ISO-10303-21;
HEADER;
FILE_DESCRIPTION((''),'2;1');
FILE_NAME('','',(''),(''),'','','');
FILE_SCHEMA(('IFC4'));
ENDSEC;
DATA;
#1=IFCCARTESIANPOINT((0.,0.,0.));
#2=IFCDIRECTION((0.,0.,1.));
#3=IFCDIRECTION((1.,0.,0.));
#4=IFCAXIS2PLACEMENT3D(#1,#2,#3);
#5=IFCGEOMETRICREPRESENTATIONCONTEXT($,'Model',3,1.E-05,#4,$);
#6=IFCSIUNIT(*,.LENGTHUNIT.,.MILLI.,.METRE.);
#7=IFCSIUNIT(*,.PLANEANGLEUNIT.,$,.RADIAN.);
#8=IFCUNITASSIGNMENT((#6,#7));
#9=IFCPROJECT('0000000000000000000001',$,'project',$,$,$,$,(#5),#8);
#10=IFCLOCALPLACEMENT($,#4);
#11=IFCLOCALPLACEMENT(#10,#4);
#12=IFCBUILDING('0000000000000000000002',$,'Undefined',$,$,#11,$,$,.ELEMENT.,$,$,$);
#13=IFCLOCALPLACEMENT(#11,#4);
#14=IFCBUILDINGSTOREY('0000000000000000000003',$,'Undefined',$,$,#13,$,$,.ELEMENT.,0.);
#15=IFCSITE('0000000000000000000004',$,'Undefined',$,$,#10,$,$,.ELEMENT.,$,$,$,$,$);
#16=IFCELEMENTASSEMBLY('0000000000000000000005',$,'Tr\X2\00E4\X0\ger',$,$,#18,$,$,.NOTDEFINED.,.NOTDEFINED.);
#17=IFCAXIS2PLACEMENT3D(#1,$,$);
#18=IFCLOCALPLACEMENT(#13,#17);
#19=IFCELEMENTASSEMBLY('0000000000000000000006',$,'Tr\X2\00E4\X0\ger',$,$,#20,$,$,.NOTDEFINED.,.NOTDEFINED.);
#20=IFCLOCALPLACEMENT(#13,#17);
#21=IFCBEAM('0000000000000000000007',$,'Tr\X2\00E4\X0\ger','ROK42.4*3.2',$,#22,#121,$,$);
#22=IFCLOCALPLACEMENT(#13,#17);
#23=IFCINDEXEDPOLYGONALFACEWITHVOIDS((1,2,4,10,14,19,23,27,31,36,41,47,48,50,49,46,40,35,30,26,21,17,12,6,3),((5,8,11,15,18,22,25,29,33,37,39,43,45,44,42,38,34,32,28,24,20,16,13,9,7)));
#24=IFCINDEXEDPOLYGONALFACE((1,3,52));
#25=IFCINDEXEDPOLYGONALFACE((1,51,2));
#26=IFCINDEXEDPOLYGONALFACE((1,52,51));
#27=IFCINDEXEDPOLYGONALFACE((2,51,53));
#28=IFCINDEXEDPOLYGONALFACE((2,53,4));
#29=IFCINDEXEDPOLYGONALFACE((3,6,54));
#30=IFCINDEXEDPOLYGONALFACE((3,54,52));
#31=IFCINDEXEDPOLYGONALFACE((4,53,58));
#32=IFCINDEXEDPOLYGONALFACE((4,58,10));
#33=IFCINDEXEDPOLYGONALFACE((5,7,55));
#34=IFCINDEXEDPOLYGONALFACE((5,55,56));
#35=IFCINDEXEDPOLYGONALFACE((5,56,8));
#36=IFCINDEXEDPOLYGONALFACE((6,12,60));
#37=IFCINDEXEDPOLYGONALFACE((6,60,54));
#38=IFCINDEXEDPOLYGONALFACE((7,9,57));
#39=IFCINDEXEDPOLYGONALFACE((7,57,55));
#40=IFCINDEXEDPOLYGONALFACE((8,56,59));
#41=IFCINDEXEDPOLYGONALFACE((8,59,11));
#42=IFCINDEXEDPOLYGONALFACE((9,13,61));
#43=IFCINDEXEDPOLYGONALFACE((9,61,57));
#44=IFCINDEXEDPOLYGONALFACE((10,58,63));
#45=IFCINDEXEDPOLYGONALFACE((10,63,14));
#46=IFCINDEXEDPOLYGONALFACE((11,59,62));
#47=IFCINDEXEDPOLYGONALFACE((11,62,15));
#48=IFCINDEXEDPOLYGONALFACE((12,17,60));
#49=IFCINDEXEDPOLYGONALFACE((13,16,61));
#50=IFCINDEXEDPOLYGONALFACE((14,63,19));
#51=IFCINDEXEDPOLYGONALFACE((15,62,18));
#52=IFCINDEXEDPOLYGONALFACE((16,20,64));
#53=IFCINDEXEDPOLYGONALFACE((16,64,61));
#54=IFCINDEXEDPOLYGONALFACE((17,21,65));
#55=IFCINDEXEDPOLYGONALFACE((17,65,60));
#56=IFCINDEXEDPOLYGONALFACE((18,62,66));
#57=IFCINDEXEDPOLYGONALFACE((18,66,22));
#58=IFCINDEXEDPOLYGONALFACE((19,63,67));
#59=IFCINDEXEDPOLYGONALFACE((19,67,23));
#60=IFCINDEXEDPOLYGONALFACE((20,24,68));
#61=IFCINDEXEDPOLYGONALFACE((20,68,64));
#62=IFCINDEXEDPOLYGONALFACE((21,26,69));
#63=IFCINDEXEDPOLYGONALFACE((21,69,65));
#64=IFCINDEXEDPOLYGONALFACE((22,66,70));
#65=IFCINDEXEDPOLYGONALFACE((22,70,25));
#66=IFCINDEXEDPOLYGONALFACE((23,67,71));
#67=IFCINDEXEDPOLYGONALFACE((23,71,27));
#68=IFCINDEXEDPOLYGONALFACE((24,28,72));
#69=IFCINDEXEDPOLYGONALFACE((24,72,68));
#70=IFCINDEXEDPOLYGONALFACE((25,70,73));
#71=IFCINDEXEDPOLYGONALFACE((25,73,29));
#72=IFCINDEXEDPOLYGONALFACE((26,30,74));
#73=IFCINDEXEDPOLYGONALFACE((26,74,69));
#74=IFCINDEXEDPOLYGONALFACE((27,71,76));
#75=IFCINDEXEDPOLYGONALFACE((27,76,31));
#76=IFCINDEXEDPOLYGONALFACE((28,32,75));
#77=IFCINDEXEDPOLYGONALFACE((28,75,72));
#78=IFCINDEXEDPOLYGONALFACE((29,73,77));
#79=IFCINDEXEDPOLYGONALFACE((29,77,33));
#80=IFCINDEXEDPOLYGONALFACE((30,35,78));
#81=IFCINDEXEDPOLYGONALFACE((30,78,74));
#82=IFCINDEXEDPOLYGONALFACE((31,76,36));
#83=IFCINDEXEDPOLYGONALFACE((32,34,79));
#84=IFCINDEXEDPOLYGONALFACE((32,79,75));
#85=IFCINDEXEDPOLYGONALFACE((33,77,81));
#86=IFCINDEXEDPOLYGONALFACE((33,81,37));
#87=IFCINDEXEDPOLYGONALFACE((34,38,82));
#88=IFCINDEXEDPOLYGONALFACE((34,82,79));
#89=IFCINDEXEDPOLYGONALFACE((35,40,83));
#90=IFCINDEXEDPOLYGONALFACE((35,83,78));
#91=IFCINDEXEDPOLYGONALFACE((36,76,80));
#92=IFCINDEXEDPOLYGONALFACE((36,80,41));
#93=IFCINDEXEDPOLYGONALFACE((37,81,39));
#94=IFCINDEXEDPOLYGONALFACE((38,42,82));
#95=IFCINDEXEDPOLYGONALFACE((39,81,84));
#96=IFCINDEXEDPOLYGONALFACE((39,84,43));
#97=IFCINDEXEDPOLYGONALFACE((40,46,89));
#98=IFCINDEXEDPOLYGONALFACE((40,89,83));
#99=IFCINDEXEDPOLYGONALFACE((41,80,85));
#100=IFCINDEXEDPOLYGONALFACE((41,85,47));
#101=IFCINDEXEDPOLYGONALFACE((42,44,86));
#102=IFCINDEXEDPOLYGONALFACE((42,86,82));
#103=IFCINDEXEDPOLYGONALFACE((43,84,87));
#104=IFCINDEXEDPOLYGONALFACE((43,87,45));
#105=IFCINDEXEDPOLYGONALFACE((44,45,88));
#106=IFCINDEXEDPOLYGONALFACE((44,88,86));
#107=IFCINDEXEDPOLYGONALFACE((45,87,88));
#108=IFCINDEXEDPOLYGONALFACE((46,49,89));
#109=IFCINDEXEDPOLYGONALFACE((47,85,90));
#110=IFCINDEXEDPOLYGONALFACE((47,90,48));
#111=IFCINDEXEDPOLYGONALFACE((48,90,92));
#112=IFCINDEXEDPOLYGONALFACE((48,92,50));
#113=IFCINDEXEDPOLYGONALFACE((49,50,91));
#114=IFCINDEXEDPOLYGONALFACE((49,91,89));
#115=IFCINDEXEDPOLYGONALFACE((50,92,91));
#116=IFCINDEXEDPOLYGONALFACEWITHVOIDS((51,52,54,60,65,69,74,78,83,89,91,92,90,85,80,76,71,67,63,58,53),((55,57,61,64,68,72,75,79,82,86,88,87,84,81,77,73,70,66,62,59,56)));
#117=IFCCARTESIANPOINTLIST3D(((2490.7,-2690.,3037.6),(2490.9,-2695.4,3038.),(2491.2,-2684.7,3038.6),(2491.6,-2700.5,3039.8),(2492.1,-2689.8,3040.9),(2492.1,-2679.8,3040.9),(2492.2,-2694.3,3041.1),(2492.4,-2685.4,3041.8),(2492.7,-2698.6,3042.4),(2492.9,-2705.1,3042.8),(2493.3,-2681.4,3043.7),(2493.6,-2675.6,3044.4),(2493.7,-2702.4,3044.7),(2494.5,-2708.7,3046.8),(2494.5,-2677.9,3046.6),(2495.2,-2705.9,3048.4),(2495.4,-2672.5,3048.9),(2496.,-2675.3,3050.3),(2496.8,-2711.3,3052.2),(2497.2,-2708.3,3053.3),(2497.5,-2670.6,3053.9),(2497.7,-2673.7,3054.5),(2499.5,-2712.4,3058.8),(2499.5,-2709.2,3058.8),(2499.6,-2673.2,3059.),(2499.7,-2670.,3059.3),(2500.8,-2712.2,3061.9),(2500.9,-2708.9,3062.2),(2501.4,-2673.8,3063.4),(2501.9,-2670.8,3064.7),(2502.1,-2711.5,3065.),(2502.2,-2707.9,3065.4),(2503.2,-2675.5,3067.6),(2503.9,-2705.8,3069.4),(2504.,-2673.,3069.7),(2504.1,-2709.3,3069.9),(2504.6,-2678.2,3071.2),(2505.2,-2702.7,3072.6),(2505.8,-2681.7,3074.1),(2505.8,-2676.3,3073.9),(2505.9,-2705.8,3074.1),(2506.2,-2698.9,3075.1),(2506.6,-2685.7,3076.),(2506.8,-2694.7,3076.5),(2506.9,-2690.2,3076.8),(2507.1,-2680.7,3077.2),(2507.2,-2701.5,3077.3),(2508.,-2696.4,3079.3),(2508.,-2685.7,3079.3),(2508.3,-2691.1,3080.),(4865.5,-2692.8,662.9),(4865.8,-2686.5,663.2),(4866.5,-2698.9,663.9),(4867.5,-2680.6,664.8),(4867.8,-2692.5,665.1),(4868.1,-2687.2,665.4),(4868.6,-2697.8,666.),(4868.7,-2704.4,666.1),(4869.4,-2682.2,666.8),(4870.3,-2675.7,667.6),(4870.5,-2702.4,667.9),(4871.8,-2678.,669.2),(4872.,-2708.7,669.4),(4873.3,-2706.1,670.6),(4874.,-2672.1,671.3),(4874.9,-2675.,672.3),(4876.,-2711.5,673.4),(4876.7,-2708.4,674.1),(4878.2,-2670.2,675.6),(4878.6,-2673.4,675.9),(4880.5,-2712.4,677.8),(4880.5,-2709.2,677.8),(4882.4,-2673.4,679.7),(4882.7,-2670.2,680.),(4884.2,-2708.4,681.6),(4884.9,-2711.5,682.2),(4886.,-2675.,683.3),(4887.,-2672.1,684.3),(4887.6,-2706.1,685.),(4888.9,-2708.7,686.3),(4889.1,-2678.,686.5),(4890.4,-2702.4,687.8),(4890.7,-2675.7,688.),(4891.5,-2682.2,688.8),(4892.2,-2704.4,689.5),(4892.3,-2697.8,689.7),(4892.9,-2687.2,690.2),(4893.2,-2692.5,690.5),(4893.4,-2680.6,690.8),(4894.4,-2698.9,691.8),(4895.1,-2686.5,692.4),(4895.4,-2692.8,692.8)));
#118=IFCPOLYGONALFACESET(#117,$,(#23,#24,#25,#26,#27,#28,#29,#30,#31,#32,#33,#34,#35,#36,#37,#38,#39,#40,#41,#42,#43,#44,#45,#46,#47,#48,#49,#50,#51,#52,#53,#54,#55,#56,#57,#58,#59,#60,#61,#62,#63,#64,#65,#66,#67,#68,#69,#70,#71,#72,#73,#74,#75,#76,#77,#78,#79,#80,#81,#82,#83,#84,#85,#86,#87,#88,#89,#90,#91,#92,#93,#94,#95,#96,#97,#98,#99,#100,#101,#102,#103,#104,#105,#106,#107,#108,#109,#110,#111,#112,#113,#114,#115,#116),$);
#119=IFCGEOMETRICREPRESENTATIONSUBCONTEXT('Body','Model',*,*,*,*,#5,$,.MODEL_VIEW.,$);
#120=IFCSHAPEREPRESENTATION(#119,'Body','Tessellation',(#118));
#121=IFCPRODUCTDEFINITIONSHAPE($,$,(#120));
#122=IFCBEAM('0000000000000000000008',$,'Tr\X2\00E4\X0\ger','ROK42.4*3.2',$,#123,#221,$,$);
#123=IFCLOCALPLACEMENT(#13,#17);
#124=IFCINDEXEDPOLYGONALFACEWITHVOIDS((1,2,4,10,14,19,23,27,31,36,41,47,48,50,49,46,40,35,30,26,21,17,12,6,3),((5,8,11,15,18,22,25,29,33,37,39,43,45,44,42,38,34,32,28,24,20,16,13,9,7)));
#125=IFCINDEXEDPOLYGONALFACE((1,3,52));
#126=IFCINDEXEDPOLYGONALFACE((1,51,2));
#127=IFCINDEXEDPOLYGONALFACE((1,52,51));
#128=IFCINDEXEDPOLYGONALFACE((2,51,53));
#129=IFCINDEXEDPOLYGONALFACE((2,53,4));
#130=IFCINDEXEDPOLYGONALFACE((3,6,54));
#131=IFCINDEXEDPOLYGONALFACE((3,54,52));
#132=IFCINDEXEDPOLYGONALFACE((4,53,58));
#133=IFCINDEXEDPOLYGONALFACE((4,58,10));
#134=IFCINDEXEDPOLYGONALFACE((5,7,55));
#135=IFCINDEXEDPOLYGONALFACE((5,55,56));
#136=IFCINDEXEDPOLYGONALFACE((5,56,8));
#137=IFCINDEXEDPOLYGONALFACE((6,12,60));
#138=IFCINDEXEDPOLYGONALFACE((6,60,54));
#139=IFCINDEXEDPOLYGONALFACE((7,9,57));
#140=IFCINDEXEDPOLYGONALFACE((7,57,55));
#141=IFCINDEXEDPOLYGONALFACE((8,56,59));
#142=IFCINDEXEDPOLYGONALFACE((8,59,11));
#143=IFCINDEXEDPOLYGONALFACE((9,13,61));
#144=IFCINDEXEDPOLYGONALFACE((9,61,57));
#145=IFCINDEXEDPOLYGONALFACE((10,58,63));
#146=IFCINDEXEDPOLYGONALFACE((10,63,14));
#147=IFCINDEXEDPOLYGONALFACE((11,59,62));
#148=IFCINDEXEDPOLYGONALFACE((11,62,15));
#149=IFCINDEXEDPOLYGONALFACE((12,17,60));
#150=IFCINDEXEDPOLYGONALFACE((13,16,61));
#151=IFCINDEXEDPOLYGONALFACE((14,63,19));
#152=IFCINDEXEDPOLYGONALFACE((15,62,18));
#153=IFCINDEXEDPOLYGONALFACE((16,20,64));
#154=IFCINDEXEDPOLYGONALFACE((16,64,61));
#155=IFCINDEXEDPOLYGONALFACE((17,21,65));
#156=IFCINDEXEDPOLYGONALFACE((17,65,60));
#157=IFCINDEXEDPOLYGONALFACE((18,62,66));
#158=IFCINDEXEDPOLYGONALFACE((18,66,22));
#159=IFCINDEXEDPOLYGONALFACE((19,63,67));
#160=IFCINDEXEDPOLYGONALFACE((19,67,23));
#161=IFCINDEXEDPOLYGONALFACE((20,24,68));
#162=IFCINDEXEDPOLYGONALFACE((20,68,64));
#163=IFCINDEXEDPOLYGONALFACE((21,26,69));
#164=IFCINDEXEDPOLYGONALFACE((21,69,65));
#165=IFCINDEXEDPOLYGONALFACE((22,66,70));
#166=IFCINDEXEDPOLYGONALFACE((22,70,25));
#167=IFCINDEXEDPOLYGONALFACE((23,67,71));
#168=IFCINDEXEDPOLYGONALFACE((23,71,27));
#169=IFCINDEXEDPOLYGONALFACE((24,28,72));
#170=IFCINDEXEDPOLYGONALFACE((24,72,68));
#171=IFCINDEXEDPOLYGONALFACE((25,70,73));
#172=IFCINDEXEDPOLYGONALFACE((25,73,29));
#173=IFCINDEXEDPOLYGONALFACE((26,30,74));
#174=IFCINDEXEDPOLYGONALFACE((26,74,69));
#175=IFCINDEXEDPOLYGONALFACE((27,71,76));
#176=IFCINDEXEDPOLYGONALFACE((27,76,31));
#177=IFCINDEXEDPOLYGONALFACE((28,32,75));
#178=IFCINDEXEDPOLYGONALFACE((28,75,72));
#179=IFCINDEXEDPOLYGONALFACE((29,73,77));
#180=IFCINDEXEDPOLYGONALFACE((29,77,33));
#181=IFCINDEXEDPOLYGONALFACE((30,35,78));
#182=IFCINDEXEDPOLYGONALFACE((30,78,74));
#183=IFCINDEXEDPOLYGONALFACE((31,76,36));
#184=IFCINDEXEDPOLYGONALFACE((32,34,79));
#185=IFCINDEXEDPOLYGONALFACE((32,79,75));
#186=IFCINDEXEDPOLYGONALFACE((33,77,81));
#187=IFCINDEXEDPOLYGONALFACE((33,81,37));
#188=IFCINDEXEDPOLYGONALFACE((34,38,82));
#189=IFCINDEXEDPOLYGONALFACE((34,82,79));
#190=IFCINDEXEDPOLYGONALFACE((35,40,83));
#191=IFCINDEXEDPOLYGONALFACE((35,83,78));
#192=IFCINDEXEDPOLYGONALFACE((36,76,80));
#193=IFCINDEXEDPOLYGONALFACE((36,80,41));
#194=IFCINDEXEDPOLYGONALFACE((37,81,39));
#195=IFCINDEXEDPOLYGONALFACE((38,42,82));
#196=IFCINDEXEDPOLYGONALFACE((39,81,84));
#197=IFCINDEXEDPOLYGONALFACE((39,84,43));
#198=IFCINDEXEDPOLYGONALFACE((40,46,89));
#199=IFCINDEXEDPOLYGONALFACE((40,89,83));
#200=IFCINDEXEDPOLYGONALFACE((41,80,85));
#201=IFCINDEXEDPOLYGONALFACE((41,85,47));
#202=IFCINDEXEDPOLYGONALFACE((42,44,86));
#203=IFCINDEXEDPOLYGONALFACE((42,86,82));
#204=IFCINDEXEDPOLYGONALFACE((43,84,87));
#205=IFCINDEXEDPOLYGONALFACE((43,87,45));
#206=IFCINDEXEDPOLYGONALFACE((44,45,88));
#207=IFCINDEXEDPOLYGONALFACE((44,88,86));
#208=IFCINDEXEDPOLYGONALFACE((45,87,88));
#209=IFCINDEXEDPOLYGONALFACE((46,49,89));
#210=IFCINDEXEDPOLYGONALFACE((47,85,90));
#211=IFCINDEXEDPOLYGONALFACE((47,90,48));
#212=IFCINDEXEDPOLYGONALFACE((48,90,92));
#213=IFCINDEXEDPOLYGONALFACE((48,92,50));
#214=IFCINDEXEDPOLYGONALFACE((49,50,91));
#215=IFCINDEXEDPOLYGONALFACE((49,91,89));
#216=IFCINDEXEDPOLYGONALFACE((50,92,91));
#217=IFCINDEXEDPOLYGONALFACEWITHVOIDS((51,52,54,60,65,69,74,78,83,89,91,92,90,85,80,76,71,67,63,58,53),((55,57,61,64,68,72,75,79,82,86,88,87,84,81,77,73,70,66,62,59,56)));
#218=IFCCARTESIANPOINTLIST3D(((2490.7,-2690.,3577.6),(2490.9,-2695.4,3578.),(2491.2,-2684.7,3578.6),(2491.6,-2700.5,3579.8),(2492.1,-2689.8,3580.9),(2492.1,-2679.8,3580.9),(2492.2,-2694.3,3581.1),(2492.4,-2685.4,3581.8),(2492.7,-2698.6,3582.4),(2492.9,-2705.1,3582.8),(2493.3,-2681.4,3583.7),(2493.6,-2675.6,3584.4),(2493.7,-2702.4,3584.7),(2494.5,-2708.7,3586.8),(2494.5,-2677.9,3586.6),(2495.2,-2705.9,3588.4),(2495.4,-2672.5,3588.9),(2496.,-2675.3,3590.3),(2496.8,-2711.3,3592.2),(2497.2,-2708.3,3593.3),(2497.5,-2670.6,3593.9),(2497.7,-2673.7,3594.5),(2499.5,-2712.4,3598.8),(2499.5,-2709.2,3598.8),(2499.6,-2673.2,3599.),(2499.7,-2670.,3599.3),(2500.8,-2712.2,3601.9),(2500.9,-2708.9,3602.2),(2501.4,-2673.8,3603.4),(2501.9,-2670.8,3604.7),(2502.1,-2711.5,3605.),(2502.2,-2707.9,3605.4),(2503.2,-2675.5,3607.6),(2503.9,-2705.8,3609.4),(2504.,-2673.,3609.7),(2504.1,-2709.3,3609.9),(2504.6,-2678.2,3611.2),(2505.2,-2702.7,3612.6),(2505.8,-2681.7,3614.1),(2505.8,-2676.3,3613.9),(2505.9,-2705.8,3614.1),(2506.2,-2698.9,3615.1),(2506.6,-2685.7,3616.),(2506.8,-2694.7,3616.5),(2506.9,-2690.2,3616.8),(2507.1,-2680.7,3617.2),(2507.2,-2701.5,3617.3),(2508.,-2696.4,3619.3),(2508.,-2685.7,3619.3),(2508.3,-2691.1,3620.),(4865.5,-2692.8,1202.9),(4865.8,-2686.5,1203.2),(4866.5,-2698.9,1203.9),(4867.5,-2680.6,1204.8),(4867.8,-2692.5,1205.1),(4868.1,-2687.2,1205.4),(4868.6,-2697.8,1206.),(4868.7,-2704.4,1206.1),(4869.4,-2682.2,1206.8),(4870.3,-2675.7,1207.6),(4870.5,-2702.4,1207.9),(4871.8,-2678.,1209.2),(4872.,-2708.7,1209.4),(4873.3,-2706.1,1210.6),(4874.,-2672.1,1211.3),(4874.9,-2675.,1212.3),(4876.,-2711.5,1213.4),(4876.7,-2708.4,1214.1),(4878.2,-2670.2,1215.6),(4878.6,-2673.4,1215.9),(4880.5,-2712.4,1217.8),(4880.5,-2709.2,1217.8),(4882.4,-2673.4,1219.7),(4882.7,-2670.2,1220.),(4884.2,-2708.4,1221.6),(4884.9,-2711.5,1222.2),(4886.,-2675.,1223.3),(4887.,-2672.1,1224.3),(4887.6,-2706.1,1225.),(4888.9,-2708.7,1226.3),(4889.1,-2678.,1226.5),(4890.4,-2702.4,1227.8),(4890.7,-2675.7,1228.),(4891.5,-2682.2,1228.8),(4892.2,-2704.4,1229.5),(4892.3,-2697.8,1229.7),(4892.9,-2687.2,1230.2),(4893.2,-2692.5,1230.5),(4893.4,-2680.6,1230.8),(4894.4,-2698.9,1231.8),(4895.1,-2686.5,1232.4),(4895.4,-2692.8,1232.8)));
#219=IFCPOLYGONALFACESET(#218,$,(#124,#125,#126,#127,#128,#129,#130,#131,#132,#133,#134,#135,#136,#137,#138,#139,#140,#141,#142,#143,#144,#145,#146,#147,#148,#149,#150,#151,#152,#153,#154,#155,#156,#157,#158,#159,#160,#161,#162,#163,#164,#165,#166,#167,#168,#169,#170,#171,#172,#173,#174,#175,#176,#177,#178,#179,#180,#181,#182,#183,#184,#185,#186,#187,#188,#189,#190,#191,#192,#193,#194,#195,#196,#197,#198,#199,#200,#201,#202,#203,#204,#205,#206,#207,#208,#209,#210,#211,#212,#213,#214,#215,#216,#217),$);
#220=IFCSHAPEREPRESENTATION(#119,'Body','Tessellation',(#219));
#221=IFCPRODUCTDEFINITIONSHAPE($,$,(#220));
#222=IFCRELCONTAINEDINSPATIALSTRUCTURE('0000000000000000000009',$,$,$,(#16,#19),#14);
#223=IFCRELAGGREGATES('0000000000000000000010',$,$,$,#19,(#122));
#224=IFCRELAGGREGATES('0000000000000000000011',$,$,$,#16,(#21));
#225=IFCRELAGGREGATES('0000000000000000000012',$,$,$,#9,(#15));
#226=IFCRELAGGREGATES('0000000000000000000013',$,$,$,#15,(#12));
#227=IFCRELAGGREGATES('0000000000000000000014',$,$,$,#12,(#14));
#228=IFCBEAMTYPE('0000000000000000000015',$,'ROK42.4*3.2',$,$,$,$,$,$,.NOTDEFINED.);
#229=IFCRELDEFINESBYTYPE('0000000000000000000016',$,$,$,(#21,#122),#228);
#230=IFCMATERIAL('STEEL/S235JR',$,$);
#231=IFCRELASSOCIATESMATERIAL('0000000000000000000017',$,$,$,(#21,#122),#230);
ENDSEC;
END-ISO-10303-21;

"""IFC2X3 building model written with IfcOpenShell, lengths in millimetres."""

from ifc_helpers import new_model, si_unit, frame, origin_with_axes, origin_2d_with_axis, place, context, subcontext, project, spatial, hollow_circle, extrude, clip, halfspace, material, type_object, element, aggregate, save


model = new_model("IFC2X3")

# Units and contexts
model_context = context("Model", 3, precision=1e-05, world=origin_with_axes())
body_context = subcontext(model_context, "Body", "Model", "MODEL_VIEW")
ifc_project = project(units=[si_unit("LENGTHUNIT", "METRE", prefix="MILLI"), si_unit("PLANEANGLEUNIT", "RADIAN")], contexts=[model_context])

# Site, building, storey
site_placement = place(None, origin_with_axes())
site = spatial("IfcSite", under=ifc_project, at=site_placement, Name="Undefined", CompositionType="ELEMENT")
building_placement = place(site_placement, origin_with_axes())
building = spatial("IfcBuilding", under=site, at=building_placement, Name="Undefined", CompositionType="ELEMENT")
storey_placement = place(building_placement, origin_with_axes())
storey = spatial("IfcBuildingStorey", under=building, at=storey_placement, Name="Undefined", CompositionType="ELEMENT", Elevation=0.0)

# Element assemblies
assembly_1_placement = place(storey_placement, origin_with_axes())
assembly_1 = element("IfcElementAssembly", 1, at=assembly_1_placement, inside=storey, Name="Träger", AssemblyPlace="NOTDEFINED", PredefinedType="NOTDEFINED")
ifc_material_1 = material(Name="STEEL/S235JR")
beam_type = type_object("IfcBeamType", Name="ROK42.4*3.2", PredefinedType="NOTDEFINED")
assembly_2_placement = place(storey_placement, origin_with_axes())
assembly_2 = element("IfcElementAssembly", 2, at=assembly_2_placement, inside=storey, Name="Träger", AssemblyPlace="NOTDEFINED", PredefinedType="NOTDEFINED")

# Beams
beam_1_placement = place(assembly_1_placement, frame((2493.3, -2691.2, 3065.0), z_axis=(0.707111, 0.0, 0.707103), x_axis=(0.707103, 0.0, -0.707111)))
beam_1 = element("IfcBeam", 3, at=beam_1_placement, type_object=beam_type, material=ifc_material_1, Name="Träger", Description="ROK42.4*3.2", context=body_context, shape_type="Clipping", body=[
    clip(extrude(hollow_circle(Radius=21.2, WallThickness=3.2, at=origin_2d_with_axis()), frame((3376.0, 0.0, 0.0), z_axis=(-1.0, 0.0, 0.0), x_axis=(0.0, -1.0, 0.0)), (0.0, 0.0, 1.0), 3410.0), halfspace(frame((0.0, 0.0, 21.2), z_axis=(0.923878, 0.0, 0.382686), x_axis=(0.0, 1.0, 0.0)), True)),
])
beam_2_placement = place(assembly_2_placement, frame((2493.3, -2691.2, 3605.0), z_axis=(0.707111, 0.0, 0.707103), x_axis=(0.707103, 0.0, -0.707111)))
beam_2 = element("IfcBeam", 4, at=beam_2_placement, type_object=beam_type, material=ifc_material_1, Name="Träger", Description="ROK42.4*3.2", context=body_context, shape_type="Clipping", body=[
    clip(extrude(hollow_circle(Radius=21.2, WallThickness=3.2, at=origin_2d_with_axis()), frame((3376.0, 0.0, 0.0), z_axis=(-1.0, 0.0, 0.0), x_axis=(0.0, -1.0, 0.0)), (0.0, 0.0, 1.0), 3410.0), halfspace(frame((0.0, 0.0, 21.2), z_axis=(0.923878, 0.0, 0.382686), x_axis=(0.0, 1.0, 0.0)), True)),
])

aggregate(assembly_2, [beam_2])
aggregate(assembly_1, [beam_1])

save(model, "model.ifc")
